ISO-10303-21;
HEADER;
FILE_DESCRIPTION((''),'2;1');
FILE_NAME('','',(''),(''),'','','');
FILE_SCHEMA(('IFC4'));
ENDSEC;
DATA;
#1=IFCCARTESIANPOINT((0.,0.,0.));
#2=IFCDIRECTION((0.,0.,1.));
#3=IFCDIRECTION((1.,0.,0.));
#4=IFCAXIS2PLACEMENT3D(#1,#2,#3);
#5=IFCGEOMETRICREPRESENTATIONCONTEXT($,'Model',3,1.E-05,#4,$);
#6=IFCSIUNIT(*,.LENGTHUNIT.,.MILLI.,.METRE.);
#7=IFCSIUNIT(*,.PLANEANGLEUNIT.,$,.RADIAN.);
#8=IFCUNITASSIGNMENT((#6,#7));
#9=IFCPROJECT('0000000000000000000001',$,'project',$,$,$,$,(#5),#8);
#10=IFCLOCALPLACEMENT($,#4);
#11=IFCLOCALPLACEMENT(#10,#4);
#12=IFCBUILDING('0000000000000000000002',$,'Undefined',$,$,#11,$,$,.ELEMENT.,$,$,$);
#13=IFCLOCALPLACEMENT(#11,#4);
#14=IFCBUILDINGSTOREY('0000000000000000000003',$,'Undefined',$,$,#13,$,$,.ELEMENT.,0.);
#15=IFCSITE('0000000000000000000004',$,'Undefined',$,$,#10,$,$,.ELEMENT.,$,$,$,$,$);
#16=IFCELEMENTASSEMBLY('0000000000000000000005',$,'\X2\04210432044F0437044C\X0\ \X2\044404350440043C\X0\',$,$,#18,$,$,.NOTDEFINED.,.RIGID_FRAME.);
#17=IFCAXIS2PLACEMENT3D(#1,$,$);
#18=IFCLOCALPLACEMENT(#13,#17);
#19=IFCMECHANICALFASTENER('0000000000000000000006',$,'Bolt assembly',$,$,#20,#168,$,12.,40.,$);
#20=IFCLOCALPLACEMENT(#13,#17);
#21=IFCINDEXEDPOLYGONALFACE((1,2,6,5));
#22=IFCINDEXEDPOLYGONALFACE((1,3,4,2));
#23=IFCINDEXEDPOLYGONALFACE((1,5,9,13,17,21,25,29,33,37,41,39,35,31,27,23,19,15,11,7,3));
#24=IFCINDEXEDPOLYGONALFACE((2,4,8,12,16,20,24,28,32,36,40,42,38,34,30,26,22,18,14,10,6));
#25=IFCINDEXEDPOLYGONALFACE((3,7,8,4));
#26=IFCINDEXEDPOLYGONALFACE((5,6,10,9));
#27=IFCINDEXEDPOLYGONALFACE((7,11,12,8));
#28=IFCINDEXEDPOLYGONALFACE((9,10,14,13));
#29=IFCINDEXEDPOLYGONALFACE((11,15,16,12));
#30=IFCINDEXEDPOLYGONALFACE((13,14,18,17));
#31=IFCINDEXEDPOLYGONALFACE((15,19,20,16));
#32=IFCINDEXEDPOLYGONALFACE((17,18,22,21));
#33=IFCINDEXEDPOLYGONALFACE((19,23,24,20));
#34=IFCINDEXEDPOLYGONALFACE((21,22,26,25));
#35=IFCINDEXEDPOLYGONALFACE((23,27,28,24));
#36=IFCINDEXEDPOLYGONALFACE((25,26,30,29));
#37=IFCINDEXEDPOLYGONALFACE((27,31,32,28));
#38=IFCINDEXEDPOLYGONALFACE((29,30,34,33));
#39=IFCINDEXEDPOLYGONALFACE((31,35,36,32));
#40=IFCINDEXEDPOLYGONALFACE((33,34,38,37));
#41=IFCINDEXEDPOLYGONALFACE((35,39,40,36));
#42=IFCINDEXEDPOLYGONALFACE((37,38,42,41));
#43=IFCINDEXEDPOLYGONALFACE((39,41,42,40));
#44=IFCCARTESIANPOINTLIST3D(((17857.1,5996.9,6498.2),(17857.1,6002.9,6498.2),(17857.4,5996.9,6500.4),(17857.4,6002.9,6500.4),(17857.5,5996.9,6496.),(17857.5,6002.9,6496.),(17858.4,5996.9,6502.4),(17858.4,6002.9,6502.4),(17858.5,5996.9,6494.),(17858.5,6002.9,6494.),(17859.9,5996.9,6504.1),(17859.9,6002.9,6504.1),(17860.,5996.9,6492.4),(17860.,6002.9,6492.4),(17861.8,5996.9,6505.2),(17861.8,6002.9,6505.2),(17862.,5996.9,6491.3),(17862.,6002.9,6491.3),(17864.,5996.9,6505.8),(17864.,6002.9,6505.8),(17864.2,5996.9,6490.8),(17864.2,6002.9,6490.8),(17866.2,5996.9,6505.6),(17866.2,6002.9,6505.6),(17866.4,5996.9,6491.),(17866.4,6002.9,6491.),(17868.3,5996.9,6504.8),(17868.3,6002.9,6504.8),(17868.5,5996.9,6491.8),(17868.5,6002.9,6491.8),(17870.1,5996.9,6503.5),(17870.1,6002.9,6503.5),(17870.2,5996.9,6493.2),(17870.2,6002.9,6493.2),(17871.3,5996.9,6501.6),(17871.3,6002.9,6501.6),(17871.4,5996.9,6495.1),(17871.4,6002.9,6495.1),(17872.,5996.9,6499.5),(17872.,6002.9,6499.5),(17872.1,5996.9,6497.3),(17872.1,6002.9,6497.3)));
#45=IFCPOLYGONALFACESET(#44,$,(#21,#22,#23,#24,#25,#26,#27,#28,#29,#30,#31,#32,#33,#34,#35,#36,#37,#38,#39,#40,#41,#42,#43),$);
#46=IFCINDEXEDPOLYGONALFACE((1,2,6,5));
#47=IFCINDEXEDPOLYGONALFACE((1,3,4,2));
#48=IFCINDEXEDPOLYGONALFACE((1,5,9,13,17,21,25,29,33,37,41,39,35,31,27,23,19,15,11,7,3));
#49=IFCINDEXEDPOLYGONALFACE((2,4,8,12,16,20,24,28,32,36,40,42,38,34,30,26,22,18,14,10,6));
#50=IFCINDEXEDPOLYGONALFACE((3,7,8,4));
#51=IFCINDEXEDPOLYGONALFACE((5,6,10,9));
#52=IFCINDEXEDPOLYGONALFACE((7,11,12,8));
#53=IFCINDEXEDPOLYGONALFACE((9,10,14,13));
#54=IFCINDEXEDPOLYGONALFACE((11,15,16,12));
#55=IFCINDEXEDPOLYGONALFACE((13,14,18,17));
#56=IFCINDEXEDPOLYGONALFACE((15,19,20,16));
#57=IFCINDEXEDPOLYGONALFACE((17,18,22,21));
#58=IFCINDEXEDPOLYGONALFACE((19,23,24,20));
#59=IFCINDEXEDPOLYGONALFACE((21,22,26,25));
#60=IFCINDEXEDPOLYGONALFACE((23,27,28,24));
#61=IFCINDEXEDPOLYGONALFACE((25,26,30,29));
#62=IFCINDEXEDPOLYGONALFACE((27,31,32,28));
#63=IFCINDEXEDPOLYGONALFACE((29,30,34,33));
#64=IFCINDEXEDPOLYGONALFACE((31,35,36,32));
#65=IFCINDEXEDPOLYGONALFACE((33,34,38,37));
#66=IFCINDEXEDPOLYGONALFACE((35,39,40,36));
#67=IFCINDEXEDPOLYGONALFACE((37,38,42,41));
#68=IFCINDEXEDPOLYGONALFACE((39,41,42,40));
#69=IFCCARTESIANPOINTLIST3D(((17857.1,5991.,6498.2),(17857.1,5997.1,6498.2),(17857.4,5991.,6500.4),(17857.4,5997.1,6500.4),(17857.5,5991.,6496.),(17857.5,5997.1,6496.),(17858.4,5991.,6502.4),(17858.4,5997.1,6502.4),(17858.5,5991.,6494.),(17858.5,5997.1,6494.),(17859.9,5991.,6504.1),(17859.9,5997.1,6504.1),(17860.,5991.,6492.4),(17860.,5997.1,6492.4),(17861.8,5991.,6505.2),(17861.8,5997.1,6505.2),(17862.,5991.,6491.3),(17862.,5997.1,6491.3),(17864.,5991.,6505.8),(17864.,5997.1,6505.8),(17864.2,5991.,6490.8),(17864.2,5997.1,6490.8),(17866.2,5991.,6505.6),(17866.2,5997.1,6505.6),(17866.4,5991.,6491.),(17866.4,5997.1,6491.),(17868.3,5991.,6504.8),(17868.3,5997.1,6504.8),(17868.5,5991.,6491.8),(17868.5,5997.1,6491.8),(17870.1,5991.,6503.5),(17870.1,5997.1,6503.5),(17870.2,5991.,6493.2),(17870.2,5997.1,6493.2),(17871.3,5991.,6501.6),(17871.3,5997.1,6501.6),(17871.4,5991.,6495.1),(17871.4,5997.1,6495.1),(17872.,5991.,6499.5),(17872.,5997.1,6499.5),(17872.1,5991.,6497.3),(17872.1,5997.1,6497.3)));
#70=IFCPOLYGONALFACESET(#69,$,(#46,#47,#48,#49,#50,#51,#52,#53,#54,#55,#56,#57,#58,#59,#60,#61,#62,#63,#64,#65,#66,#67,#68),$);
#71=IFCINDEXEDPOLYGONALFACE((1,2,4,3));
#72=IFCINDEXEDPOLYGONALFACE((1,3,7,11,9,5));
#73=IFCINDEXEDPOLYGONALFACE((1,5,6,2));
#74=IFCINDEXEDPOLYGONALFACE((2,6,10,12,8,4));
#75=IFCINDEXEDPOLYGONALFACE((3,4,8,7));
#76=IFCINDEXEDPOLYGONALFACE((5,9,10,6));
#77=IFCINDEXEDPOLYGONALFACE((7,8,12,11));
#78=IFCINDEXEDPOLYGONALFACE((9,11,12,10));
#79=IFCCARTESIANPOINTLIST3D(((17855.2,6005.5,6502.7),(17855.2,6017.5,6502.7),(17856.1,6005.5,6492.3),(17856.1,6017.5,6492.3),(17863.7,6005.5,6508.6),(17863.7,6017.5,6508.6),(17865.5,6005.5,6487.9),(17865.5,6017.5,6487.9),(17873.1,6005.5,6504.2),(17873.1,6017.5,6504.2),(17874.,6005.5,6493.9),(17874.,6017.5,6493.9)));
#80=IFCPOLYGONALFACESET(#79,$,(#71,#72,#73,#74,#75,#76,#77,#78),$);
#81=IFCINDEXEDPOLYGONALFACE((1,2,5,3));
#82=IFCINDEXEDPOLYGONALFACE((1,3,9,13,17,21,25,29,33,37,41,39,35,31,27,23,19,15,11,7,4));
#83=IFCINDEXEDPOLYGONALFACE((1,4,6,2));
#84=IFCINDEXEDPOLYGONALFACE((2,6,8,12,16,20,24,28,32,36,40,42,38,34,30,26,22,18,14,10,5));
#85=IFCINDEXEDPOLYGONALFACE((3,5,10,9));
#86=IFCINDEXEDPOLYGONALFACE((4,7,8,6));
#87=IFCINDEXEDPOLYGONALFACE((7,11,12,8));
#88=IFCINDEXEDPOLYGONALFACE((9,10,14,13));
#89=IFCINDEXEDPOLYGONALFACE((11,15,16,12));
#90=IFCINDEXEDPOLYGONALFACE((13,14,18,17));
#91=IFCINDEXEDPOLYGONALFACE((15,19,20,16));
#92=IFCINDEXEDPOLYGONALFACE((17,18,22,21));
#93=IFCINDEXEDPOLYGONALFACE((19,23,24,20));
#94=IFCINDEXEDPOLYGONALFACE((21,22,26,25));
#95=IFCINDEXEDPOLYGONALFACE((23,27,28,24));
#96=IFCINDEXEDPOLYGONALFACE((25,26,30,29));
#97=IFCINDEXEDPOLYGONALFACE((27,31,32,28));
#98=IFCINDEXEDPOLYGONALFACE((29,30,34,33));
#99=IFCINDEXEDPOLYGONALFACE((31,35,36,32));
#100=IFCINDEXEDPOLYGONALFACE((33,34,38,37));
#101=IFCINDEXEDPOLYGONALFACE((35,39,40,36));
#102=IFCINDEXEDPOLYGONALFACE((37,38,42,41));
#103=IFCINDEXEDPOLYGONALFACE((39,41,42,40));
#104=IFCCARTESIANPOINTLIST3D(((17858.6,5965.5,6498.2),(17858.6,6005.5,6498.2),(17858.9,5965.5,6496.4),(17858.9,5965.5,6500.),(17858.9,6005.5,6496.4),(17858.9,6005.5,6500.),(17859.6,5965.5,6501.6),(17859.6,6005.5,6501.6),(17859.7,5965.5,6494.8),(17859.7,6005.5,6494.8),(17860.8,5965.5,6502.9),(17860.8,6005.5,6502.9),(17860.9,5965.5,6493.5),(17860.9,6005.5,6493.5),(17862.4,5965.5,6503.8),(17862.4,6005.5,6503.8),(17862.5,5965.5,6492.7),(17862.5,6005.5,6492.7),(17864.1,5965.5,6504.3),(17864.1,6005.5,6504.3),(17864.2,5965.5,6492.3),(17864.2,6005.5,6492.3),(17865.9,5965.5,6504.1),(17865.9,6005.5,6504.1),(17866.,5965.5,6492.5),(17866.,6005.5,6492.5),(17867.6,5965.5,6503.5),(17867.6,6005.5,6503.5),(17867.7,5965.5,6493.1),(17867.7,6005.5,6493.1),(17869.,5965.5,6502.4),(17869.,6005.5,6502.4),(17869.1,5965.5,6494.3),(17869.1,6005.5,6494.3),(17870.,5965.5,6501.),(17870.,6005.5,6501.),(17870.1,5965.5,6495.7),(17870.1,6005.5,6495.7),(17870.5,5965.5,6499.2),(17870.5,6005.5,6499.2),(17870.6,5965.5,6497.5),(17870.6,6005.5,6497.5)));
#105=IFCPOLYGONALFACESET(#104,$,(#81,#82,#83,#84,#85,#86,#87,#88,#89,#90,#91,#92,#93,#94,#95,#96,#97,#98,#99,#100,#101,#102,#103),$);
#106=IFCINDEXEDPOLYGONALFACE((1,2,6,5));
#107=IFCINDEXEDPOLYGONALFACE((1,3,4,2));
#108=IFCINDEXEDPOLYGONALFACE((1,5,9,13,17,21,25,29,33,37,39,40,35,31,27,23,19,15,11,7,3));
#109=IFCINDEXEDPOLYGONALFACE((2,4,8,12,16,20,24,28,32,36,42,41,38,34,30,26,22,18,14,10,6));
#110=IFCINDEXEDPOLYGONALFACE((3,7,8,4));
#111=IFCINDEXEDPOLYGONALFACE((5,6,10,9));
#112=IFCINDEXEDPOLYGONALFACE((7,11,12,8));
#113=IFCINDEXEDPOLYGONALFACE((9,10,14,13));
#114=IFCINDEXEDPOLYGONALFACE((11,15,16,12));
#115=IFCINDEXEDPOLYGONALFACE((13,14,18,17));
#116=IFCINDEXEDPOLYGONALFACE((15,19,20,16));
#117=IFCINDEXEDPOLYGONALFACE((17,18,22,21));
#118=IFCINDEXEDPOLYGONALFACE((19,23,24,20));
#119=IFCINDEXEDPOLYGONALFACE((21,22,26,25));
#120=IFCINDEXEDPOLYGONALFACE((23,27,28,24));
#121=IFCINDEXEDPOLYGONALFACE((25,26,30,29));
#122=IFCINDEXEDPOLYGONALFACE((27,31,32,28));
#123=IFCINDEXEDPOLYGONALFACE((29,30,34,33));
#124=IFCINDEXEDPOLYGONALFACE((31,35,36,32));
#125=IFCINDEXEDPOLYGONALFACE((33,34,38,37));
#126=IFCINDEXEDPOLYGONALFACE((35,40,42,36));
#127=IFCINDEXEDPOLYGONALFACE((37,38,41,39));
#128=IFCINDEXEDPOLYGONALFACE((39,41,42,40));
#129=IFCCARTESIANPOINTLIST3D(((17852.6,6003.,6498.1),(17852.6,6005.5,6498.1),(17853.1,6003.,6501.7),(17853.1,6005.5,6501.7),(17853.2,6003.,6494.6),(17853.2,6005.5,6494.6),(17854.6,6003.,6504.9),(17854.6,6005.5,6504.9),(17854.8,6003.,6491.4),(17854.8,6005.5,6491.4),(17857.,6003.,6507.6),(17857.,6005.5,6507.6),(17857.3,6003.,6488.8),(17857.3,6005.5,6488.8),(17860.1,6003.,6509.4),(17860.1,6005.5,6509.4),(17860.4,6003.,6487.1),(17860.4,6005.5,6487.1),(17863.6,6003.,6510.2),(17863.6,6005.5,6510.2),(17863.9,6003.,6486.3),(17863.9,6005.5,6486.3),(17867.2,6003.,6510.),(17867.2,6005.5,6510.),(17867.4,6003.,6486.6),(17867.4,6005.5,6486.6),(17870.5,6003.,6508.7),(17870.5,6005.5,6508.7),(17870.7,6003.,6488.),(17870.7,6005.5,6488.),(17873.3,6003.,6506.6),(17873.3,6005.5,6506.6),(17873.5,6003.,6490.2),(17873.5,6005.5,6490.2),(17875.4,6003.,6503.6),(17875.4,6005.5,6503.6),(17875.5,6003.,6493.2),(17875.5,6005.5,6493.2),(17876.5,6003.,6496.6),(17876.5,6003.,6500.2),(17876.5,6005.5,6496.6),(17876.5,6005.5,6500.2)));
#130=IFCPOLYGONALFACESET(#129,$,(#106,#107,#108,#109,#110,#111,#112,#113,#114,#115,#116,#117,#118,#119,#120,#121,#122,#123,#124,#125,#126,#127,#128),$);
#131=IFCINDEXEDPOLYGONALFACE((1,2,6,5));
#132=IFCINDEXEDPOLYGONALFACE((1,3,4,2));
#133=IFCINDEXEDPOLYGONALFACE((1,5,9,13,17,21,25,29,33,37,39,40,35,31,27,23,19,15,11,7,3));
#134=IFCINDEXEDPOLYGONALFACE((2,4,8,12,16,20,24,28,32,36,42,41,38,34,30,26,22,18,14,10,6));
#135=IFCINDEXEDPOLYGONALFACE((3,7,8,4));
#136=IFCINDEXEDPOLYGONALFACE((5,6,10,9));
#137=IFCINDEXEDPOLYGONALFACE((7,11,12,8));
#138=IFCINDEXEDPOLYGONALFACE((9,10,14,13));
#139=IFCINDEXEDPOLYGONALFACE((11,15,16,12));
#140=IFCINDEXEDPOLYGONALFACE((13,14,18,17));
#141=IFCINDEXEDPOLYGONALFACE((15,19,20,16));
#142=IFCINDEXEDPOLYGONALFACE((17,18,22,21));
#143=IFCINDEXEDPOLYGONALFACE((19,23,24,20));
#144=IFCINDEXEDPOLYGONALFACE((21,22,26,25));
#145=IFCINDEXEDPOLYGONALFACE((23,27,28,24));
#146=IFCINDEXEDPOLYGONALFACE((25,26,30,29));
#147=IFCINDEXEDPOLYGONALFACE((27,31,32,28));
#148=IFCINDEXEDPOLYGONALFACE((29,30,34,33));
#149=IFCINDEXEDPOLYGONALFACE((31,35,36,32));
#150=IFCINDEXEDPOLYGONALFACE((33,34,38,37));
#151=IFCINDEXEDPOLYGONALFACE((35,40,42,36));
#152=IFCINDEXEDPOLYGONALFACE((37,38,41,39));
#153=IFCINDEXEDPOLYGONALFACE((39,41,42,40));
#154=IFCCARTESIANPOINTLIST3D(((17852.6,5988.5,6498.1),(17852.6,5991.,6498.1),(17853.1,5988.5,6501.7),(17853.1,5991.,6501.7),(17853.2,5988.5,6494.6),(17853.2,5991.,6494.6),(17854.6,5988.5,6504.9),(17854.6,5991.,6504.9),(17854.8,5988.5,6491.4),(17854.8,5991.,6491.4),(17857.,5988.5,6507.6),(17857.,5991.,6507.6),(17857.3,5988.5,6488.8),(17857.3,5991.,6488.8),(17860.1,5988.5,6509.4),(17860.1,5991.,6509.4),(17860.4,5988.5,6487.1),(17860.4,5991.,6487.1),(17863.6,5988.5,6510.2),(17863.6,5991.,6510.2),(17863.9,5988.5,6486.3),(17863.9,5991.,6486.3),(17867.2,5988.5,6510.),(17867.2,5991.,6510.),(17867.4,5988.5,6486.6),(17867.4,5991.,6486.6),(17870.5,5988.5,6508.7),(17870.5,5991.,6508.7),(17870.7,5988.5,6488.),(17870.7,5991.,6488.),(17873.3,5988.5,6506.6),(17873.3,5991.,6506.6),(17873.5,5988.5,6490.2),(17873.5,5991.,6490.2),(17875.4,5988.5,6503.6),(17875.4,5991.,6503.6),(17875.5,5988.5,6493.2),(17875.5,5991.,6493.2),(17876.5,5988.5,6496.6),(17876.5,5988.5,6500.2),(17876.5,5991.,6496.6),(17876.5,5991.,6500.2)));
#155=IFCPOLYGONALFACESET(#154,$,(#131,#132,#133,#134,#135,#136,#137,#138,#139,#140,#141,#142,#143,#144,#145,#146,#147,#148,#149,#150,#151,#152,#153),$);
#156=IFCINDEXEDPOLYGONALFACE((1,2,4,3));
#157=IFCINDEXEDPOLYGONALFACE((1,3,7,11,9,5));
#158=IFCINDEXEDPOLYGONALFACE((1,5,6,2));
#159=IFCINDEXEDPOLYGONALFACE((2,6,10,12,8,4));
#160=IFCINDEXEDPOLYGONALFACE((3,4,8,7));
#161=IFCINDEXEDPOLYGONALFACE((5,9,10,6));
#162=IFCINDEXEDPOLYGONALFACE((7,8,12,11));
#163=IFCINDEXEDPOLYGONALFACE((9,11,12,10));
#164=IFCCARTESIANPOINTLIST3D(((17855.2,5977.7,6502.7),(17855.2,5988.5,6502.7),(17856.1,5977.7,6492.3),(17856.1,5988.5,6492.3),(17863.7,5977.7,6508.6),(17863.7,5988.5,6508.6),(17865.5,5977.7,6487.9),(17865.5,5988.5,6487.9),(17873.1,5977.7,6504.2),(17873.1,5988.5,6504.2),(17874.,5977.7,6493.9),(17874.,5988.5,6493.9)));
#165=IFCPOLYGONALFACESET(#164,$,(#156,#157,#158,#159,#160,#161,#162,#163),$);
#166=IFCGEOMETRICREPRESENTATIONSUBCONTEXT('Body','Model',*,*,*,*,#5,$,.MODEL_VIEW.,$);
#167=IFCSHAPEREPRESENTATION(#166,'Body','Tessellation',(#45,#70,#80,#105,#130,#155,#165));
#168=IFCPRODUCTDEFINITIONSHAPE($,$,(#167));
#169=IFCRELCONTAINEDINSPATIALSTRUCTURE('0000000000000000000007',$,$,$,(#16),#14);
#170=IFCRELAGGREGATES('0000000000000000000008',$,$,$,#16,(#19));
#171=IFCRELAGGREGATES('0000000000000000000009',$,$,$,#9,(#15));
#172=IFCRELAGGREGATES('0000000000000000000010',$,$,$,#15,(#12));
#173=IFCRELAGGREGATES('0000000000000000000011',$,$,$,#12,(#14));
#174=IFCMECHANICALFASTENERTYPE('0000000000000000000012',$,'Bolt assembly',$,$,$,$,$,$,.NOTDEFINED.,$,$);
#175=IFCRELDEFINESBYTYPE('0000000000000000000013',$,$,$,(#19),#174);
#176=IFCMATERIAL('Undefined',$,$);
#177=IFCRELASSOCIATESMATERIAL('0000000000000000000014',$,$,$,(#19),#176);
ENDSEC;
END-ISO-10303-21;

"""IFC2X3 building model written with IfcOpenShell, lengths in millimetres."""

from ifc_helpers import new_model, si_unit, frame, origin_with_axes, origin_2d_with_axis, place, context, subcontext, project, spatial, polyline, circle, outline, extrude, source, transform, mapped, material, type_object, element, aggregate, save


model = new_model("IFC2X3")

# Units and contexts
model_context = context("Model", 3, precision=1e-05, world=origin_with_axes())
body_context = subcontext(model_context, "Body", "Model", "MODEL_VIEW")
ifc_project = project(units=[si_unit("LENGTHUNIT", "METRE", prefix="MILLI"), si_unit("PLANEANGLEUNIT", "RADIAN")], contexts=[model_context])

# Site, building, storey
site_placement = place(None, origin_with_axes())
site = spatial("IfcSite", under=ifc_project, at=site_placement, Name="Undefined", CompositionType="ELEMENT")
building_placement = place(site_placement, origin_with_axes())
building = spatial("IfcBuilding", under=site, at=building_placement, Name="Undefined", CompositionType="ELEMENT")
storey_placement = place(building_placement, origin_with_axes())
storey = spatial("IfcBuildingStorey", under=building, at=storey_placement, Name="Undefined", CompositionType="ELEMENT", Elevation=0.0)

# Element assembly
assembly_1_placement = place(storey_placement, origin_with_axes())
assembly_1 = element("IfcElementAssembly", 1, at=assembly_1_placement, inside=storey, Name="Связь ферм", AssemblyPlace="NOTDEFINED", PredefinedType="RIGID_FRAME")

# Mechanical fastener
ifc_material_1 = material(Name="Undefined")
mechanical_fastener_type = type_object("IfcMechanicalFastenerType", Name="Bolt assembly")
shared_shape_1 = source(origin_with_axes(), body_context, "Body", "SweptSolid", [
    extrude(circle(Radius=7.5, at=origin_2d_with_axis()), frame((0.0, 0.1, 0.0), z_axis=(0.0, 1.0, 0.0), x_axis=(1.0, 0.0, 0.0)), (0.0, 0.0, 1.0), 6.0),
    extrude(circle(Radius=7.5, at=origin_2d_with_axis()), frame((0.0, 5.9, 0.0), z_axis=(0.0, 1.0, 0.0), x_axis=(1.0, 0.0, 0.0)), (0.0, 0.0, 1.0), 6.1),
    extrude(outline(polyline([(10.4, 0.0), (5.2, 9.0), (-5.2, 9.0), (-10.4, 0.0), (-5.2, -9.0), (5.2, -9.0), (10.4, 0.0)])), frame((0.0, -14.5, 0.0), z_axis=(0.0, 1.0, 0.0), x_axis=(1.0, 0.0, 0.0)), (0.0, 0.0, 1.0), 12.0),
    extrude(circle(Radius=6.0, at=origin_2d_with_axis()), frame((0.0, -2.5, 0.0), z_axis=(0.0, 1.0, 0.0), x_axis=(1.0, 0.0, 0.0)), (0.0, 0.0, 1.0), 40.0),
    extrude(circle(Radius=12.0, at=origin_2d_with_axis()), frame((0.0, -2.5, 0.0), z_axis=(0.0, 1.0, 0.0), x_axis=(1.0, 0.0, 0.0)), (0.0, 0.0, 1.0), 2.5),
    extrude(circle(Radius=12.0, at=origin_2d_with_axis()), frame((0.0, 12.0, 0.0), z_axis=(0.0, 1.0, 0.0), x_axis=(1.0, 0.0, 0.0)), (0.0, 0.0, 1.0), 2.5),
    extrude(outline(polyline([(10.4, 0.0), (5.2, 9.0), (-5.2, 9.0), (-10.4, 0.0), (-5.2, -9.0), (5.2, -9.0), (10.4, 0.0)])), frame((0.0, 14.5, 0.0), z_axis=(0.0, 1.0, 0.0), x_axis=(1.0, 0.0, 0.0)), (0.0, 0.0, 1.0), 10.8),
])
mechanical_fastener_1_placement = place(assembly_1_placement, frame((17864.6, 6003.0, 6498.3), z_axis=(-0.573078, 0.0, 0.819501), x_axis=(-0.819501, 0.0, -0.573078)))
mechanical_fastener_1 = element("IfcMechanicalFastener", 2, at=mechanical_fastener_1_placement, type_object=mechanical_fastener_type, material=ifc_material_1, Name="Bolt assembly", NominalDiameter=12.0, NominalLength=40.0, context=body_context, shape_type="MappedRepresentation", body=[
    mapped(shared_shape_1, transform((0.0, 0.0, 0.0))),
])
aggregate(assembly_1, [mechanical_fastener_1])

save(model, "model.ifc")
